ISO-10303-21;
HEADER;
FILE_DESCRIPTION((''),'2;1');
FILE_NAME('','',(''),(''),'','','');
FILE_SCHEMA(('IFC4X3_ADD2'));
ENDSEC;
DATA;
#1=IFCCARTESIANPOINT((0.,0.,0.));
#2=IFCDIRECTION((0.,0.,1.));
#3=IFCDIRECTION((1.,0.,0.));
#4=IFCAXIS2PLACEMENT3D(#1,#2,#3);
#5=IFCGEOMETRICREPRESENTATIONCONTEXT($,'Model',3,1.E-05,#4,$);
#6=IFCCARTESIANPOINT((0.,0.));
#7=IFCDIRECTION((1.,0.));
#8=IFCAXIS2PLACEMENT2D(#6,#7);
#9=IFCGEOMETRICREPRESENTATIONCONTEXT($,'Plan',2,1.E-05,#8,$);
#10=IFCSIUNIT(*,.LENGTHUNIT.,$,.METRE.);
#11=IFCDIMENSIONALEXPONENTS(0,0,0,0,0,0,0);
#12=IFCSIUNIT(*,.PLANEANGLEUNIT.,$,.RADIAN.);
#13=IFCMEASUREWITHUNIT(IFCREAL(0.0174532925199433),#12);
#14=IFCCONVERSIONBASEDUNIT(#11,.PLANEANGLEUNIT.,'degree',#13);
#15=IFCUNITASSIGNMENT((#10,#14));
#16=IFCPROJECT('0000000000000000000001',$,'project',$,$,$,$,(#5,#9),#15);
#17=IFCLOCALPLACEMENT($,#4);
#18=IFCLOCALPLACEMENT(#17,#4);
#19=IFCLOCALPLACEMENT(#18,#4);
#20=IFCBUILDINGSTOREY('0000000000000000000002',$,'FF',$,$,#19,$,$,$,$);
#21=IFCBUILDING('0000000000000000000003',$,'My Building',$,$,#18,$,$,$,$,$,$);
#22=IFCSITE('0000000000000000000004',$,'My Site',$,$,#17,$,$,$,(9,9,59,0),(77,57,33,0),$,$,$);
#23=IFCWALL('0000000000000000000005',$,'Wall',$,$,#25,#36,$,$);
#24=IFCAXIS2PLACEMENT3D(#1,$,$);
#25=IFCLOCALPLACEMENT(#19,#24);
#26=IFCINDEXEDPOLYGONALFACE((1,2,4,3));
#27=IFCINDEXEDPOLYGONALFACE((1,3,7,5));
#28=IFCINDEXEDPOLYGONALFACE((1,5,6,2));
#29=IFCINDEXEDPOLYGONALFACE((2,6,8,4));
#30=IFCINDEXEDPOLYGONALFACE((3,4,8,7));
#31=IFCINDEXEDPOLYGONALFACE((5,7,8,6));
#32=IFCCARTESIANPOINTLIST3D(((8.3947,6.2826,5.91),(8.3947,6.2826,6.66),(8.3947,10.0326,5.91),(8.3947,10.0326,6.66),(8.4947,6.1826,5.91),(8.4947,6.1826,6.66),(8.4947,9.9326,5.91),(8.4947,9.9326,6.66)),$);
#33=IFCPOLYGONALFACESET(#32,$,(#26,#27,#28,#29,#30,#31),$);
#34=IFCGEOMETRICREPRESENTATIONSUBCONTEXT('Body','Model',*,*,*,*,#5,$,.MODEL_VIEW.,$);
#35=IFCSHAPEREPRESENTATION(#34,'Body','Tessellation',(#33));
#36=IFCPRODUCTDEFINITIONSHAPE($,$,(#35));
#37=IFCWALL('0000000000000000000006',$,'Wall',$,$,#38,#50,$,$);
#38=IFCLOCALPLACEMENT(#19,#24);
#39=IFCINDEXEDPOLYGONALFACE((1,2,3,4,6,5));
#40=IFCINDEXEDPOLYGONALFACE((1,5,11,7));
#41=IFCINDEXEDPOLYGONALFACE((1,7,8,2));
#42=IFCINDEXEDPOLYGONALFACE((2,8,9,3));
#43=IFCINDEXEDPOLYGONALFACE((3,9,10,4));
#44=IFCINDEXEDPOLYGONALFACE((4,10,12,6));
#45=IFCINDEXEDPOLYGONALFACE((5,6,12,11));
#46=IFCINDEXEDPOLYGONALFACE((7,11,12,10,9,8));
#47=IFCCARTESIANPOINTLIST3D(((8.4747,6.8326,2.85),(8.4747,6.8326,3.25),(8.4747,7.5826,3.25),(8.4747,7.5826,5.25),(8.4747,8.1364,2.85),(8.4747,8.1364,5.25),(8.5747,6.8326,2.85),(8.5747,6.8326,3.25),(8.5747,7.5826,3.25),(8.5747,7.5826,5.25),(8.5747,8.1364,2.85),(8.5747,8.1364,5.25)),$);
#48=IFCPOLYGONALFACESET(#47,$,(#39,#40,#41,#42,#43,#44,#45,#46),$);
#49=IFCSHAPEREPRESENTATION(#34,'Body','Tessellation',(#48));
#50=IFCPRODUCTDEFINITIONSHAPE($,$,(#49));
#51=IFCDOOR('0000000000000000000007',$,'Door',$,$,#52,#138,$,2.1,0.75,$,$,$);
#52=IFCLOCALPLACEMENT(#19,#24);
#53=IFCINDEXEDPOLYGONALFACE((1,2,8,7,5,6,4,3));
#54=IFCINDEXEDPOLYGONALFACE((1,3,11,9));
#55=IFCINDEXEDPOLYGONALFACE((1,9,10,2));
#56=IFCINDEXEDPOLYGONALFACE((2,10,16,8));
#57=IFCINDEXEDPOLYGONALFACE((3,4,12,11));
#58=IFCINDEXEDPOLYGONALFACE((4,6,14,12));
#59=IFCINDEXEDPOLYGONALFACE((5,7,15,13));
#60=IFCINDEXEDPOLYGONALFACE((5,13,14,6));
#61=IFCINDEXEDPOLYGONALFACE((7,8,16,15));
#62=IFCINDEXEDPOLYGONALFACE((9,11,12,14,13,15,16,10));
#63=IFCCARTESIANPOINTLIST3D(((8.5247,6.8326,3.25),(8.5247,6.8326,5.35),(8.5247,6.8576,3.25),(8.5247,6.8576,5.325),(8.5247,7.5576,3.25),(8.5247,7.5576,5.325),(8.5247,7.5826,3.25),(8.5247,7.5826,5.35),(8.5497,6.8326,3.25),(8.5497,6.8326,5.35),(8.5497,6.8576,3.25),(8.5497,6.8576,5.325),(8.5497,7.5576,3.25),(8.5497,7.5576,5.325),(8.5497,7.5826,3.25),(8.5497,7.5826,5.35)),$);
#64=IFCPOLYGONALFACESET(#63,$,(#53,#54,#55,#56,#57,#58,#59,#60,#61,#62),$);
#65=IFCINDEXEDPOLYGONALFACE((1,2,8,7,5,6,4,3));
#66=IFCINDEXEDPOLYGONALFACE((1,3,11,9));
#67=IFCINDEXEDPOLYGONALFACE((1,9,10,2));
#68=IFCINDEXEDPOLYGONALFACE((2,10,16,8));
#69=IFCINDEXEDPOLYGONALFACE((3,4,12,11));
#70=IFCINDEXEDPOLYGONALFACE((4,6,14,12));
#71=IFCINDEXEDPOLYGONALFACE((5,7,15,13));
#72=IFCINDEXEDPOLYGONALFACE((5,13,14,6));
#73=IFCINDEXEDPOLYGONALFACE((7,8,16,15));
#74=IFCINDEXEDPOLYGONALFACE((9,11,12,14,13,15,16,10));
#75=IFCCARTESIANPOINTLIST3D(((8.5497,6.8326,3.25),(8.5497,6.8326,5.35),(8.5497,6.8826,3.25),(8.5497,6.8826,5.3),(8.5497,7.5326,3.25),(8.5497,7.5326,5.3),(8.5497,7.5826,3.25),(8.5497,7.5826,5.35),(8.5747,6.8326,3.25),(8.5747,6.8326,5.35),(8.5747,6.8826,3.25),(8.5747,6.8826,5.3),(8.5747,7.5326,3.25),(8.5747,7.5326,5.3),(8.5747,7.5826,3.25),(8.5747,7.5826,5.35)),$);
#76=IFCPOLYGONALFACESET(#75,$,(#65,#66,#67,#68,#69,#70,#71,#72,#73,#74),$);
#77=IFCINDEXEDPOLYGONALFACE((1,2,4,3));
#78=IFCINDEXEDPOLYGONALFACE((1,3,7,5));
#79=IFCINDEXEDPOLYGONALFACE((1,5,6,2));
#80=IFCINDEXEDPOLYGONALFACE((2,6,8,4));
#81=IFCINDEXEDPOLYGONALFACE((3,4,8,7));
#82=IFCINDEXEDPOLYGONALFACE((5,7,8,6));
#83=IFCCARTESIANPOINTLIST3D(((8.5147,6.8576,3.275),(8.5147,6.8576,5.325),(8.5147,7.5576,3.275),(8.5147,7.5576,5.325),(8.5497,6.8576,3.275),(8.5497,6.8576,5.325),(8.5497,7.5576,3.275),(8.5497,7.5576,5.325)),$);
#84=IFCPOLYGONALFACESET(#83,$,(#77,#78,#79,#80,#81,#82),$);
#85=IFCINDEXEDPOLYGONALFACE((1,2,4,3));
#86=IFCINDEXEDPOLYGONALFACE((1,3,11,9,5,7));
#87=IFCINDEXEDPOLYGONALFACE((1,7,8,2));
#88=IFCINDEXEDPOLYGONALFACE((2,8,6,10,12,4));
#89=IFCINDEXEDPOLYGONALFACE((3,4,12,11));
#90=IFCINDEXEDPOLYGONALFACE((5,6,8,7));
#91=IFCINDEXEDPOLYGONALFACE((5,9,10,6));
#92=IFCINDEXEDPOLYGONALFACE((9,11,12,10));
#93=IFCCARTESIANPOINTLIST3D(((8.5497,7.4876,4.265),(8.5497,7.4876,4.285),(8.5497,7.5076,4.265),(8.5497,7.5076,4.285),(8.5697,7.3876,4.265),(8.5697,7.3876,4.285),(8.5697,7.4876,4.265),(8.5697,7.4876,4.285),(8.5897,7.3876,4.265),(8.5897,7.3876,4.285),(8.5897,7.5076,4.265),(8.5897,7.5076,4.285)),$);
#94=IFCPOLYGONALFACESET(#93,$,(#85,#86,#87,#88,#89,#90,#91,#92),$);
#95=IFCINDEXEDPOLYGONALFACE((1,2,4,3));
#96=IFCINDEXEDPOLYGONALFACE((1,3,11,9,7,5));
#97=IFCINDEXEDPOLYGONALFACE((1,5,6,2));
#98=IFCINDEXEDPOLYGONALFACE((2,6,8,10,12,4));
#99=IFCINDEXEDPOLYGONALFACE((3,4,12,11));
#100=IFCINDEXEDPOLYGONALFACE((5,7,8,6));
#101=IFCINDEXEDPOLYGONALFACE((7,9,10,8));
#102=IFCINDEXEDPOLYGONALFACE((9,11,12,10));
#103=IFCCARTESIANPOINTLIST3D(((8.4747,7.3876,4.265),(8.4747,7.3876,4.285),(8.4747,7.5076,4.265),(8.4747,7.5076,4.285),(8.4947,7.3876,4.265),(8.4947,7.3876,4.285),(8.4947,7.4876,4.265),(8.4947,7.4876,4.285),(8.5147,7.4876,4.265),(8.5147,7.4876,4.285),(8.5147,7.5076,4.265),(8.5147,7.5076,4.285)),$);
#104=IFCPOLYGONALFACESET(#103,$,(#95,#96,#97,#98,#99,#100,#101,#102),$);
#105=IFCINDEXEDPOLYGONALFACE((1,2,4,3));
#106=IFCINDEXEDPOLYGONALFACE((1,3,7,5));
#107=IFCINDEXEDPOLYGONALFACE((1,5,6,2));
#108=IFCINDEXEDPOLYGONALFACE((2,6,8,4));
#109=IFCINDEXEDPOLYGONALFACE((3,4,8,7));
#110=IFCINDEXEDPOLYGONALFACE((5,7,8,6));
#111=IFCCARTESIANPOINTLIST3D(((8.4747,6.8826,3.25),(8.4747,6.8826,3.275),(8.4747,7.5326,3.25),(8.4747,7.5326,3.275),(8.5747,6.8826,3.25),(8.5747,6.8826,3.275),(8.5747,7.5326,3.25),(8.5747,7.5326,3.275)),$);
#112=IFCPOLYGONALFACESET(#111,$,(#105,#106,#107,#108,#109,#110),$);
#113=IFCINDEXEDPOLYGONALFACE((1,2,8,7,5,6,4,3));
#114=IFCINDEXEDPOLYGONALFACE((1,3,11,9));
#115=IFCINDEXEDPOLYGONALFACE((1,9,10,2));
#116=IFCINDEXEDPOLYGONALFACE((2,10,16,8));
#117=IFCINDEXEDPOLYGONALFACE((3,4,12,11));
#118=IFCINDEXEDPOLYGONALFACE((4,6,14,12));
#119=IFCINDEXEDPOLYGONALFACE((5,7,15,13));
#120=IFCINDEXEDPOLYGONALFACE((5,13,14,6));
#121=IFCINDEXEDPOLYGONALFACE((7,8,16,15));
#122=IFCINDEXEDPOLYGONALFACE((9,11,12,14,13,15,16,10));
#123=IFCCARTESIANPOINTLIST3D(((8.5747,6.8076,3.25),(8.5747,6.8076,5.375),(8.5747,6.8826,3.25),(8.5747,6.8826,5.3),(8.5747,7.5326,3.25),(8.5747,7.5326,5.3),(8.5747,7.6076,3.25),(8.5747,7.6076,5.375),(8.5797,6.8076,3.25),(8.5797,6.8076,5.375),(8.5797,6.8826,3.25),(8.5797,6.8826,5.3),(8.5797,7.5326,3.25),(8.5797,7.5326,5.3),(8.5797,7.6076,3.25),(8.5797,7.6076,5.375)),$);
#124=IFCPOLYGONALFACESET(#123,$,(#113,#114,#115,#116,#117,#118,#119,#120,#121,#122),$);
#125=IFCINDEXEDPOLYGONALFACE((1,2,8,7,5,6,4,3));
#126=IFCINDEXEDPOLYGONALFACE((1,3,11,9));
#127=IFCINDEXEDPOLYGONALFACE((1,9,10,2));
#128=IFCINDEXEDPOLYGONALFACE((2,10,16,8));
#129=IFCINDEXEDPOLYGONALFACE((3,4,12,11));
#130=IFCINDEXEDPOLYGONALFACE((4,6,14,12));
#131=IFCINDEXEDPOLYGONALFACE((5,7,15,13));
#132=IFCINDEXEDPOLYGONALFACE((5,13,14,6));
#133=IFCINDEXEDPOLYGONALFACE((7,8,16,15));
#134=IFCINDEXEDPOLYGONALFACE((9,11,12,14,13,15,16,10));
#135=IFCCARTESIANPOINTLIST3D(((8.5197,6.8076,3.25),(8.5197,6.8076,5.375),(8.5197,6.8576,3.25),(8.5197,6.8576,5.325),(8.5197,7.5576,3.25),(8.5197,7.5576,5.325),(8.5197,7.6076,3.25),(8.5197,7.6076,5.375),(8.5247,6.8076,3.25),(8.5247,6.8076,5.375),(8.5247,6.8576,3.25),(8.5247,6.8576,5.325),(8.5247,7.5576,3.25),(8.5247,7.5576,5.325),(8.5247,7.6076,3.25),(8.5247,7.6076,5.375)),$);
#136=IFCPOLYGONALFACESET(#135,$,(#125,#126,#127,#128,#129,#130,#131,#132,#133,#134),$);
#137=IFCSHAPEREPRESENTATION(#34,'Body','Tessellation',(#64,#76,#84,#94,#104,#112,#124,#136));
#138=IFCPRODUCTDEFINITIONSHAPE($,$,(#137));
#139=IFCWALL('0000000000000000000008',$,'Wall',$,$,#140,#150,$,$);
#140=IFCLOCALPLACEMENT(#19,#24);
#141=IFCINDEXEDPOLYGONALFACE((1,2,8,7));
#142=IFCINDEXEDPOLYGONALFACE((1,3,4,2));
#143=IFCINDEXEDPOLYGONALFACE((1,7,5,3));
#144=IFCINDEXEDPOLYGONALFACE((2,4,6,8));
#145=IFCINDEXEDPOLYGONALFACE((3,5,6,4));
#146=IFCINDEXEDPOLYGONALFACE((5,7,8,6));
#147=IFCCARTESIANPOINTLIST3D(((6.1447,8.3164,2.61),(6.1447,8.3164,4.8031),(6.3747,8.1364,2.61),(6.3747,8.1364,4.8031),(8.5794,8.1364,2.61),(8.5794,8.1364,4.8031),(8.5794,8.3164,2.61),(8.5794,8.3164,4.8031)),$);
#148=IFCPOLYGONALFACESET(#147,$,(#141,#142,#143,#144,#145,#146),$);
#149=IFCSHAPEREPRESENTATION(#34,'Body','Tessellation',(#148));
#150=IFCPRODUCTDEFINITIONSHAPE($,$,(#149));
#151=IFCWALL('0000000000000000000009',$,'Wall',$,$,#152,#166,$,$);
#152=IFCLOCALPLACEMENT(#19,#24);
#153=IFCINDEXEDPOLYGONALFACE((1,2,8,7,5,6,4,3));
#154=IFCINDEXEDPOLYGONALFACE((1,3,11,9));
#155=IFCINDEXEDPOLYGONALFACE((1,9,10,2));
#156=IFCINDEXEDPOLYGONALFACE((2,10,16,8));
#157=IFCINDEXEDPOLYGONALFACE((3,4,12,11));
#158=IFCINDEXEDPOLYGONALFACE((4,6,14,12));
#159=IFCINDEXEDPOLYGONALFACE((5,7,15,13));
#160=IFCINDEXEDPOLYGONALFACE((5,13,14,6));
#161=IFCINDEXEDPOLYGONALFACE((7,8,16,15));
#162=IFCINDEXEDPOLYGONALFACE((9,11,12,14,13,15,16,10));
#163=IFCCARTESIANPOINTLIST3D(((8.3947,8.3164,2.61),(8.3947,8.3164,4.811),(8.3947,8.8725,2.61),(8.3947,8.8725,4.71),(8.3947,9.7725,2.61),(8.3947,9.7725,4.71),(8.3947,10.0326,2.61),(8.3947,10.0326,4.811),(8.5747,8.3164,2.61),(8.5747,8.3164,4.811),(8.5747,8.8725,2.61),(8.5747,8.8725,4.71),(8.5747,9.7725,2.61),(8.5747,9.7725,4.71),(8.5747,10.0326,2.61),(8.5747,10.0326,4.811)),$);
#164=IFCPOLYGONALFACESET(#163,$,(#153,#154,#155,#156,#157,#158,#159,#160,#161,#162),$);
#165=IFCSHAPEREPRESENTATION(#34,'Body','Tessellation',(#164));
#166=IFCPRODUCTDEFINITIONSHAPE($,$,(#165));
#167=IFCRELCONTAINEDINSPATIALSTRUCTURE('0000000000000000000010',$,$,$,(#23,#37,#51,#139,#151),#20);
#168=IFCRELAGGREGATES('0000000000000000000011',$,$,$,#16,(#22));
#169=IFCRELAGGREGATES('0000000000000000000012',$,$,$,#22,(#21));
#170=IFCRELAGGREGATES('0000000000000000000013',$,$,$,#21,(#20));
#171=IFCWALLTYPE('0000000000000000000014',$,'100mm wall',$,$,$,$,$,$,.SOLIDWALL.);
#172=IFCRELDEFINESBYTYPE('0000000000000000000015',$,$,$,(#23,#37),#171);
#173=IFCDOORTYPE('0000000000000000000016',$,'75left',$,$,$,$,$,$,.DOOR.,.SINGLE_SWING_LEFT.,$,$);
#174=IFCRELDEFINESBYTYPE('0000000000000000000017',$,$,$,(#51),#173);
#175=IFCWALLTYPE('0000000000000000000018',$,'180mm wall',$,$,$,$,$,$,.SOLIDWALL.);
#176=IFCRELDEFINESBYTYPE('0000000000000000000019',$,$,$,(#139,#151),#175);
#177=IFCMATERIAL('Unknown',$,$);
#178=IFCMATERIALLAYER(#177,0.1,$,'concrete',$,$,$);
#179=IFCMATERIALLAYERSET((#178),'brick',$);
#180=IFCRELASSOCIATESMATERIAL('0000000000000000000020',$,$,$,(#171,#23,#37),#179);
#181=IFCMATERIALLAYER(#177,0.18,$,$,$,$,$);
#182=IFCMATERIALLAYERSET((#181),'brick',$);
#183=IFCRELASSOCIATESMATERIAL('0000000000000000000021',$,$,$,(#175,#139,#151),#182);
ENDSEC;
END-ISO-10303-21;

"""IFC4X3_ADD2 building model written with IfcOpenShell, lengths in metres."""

from ifc_helpers import new_model, entity, si_unit, converted_unit, frame, origin_with_axes, origin_2d_with_axis, place, context, subcontext, project, spatial, line, indexed_curve, outline, extrude, shape, source, transform, mapped, material, layer, layer_set, layer_usage, type_object, type_shapes, element, fill, save


model = new_model("IFC4X3_ADD2")

# Units and contexts
model_context = context("Model", 3, precision=1e-05, world=origin_with_axes())
plan_context = context("Plan", 2, precision=1e-05, world=origin_2d_with_axis())
body_context_1 = subcontext(model_context, "Body", "Model", "MODEL_VIEW")
body_context_2 = subcontext(plan_context, "Body", "Plan", "PLAN_VIEW")
ifc_project = project(units=[si_unit("LENGTHUNIT", "METRE"), converted_unit("PLANEANGLEUNIT", "degree", entity("IfcReal", 0.0174532925199433), si_unit("PLANEANGLEUNIT", "RADIAN"), dimensions=[0, 0, 0, 0, 0, 0, 0])], contexts=[model_context, plan_context])

# Site, building, storey
site_placement = place(None, origin_with_axes())
site = spatial("IfcSite", under=ifc_project, at=site_placement, Name="My Site", RefLatitude=(9, 9, 59, 0), RefLongitude=(77, 57, 33, 0))
building_placement = place(site_placement, origin_with_axes())
building = spatial("IfcBuilding", under=site, at=building_placement, Name="My Building")
storey_placement = place(building_placement, origin_with_axes())
storey = spatial("IfcBuildingStorey", under=building, at=storey_placement, Name="FF")

# Shared definitions
ifc_material = material(Name="Unknown")

# Wall
ifc_layer_1 = layer(ifc_material, 0.1, Name="concrete")
ifc_layer_set_1 = layer_set([ifc_layer_1], Name="brick")
wall_type_1 = type_object("IfcWallType", Name="100mm wall", PredefinedType="SOLIDWALL", material=ifc_layer_set_1)
ifc_layer_usage_1 = layer_usage(ifc_layer_set_1, "AXIS2", "POSITIVE", 0.0)
wall_1_placement = place(storey_placement, frame((8.3947, 10.0326, 5.91), z_axis=(0.0, 0.0, 1.0), x_axis=(-0.000001, -1.0, 0.0)))
element("IfcWall", 1, at=wall_1_placement, inside=storey, type_object=wall_type_1, material=ifc_layer_usage_1, Name="Wall", context=body_context_1, shape_type="SweptSolid", body=[
    extrude(outline(indexed_curve([(0.0, 0.0), (0.1, 0.1), (3.85, 0.1), (3.75, 0.0)], segments=[line(1, 2, 3, 4, 1)])), origin_with_axes(), (0.0, 0.0, 1.0), 0.75),
])

# Wall, opening, door
ifc_layer_usage_2 = layer_usage(ifc_layer_set_1, "AXIS2", "POSITIVE", 0.0)
wall_2_placement = place(storey_placement, frame((8.5747, 6.8326, 2.85), z_axis=(0.0, 0.0, 1.0), x_axis=(0.0, 1.0, 0.0)))
wall_2 = element("IfcWall", 2, at=wall_2_placement, inside=storey, type_object=wall_type_1, material=ifc_layer_usage_2, Name="Wall", context=body_context_1, shape_type="SweptSolid", body=[
    extrude(outline(indexed_curve([(0.0, 0.0), (0.0, 0.1), (1.3039, 0.1), (1.3039, 0.0)], segments=[line(1, 2, 3, 4, 1)])), origin_with_axes(), (0.0, 0.0, 1.0), 2.4),
])
shared_shape_1 = source(origin_with_axes(), body_context_1, "Body", "SweptSolid", [
    extrude(outline(indexed_curve([(0.0, 0.0), (0.75, 0.0), (0.75, 2.1), (0.0, 2.1)], segments=[line(1, 2, 3, 4, 1)])), frame((0.0, -0.6, 0.0), z_axis=(0.0, -1.0, 0.0), x_axis=(1.0, 0.0, 0.0)), (0.0, 0.0, -1.0), 1.2),
])
opening_1_placement = place(wall_2_placement, frame((0.0, 0.0, 0.4), z_axis=(0.0, 0.0, 1.0), x_axis=(1.0, 0.0, 0.0)))
opening_1 = element("IfcOpeningElement", 3, at=opening_1_placement, cuts=wall_2, PredefinedType="OPENING", context=body_context_1, shape_type="MappedRepresentation", body=[
    mapped(shared_shape_1, transform((0.0, 0.0, 0.0), x_axis=(1.0, 0.0, 0.0), y_axis=(0.0, 1.0, 0.0), z_axis=(0.0, 0.0, 1.0), scale=1.0)),
])
door_type_1 = type_object("IfcDoorType", Name="75left", OperationType="SINGLE_SWING_LEFT", PredefinedType="DOOR")
shared_shape_2 = source(origin_with_axes(), body_context_1, "Body", "SweptSolid", [
    extrude(outline(indexed_curve([(0.0, 0.0), (0.0, 2.1), (0.75, 2.1), (0.75, 0.0), (0.725, 0.0), (0.725, 2.075), (0.025, 2.075), (0.025, 0.0)], segments=[line(1, 2, 3, 4, 5, 6, 7, 8, 1)])), frame((0.0, 0.025, 0.0), z_axis=(0.0, -1.0, 0.0), x_axis=(1.0, 0.0, 0.0)), (0.0, 0.0, -1.0), 0.025),
    extrude(outline(indexed_curve([(0.0, 0.0), (0.0, 2.1), (0.75, 2.1), (0.75, 0.0), (0.7, 0.0), (0.7, 2.05), (0.05, 2.05), (0.05, 0.0)], segments=[line(1, 2, 3, 4, 5, 6, 7, 8, 1)])), frame((0.0, 0.0, 0.0), z_axis=(0.0, -1.0, 0.0), x_axis=(1.0, 0.0, 0.0)), (0.0, 0.0, -1.0), 0.025),
    extrude(outline(indexed_curve([(0.0, 0.0), (0.7, 0.0), (0.7, 0.035), (0.0, 0.035)], segments=[line(1, 2, 3, 4, 1)])), frame((0.025, 0.025, 0.025), z_axis=(0.0, 0.0, 1.0), x_axis=(1.0, 0.0, 0.0)), (0.0, 0.0, 1.0), 2.05),
    extrude(outline(indexed_curve([(0.0, 0.0), (0.0, -0.04), (-0.12, -0.04), (-0.12, -0.02), (-0.02, -0.02), (-0.02, 0.0)], segments=[line(1, 2, 3, 4, 5, 6, 1)])), frame((0.675, 0.025, 1.015), z_axis=(0.0, 0.0, 1.0), x_axis=(1.0, 0.0, 0.0)), (0.0, 0.0, 1.0), 0.02),
    extrude(outline(indexed_curve([(0.0, 0.0), (0.0, 0.04), (-0.12, 0.04), (-0.12, 0.02), (-0.02, 0.02), (-0.02, 0.0)], segments=[line(1, 2, 3, 4, 5, 6, 1)])), frame((0.675, 0.06, 1.015), z_axis=(0.0, 0.0, 1.0), x_axis=(1.0, 0.0, 0.0)), (0.0, 0.0, 1.0), 0.02),
    extrude(outline(indexed_curve([(0.0, 0.0), (0.65, 0.0), (0.65, 0.1), (0.0, 0.1)], segments=[line(1, 2, 3, 4, 1)])), frame((0.05, 0.0, 0.0), z_axis=(0.0, 0.0, 1.0), x_axis=(1.0, 0.0, 0.0)), (0.0, 0.0, 1.0), 0.025),
    extrude(outline(indexed_curve([(0.0, 0.0), (0.0, 2.125), (0.8, 2.125), (0.8, 0.0), (0.725, 0.0), (0.725, 2.05), (0.075, 2.05), (0.075, 0.0)], segments=[line(1, 2, 3, 4, 5, 6, 7, 8, 1)])), frame((-0.025, -0.005, 0.0), z_axis=(0.0, -1.0, 0.0), x_axis=(1.0, 0.0, 0.0)), (0.0, 0.0, -1.0), 0.005),
    extrude(outline(indexed_curve([(0.0, 0.0), (0.0, 2.125), (0.8, 2.125), (0.8, 0.0), (0.75, 0.0), (0.75, 2.075), (0.05, 2.075), (0.05, 0.0)], segments=[line(1, 2, 3, 4, 5, 6, 7, 8, 1)])), frame((-0.025, 0.05, 0.0), z_axis=(0.0, -1.0, 0.0), x_axis=(1.0, 0.0, 0.0)), (0.0, 0.0, -1.0), 0.005),
])
shared_shape_3 = source(origin_with_axes(), body_context_2, "Body", "Curve2D", [
    entity("IfcIndexedPolyCurve", entity("IfcCartesianPointList2D", [[0.0, 0.0], [0.0, 0.05], [0.025, 0.05], [0.025, 0.025], [0.05, 0.025], [0.05, 0.0]]), [entity("IfcLineIndex", [1, 2, 3, 4, 5, 6, 1])]),
    entity("IfcIndexedPolyCurve", entity("IfcCartesianPointList2D", [[0.75, 0.0], [0.75, 0.05], [0.725, 0.05], [0.725, 0.025], [0.7, 0.025], [0.7, 0.0]]), [entity("IfcLineIndex", [1, 2, 3, 4, 5, 6, 1])]),
    entity("IfcTrimmedCurve", entity("IfcEllipse", entity("IfcAxis2Placement2D", entity("IfcCartesianPoint", [0.06, 0.05]), entity("IfcDirection", [1.0, 0.0])), 0.665, 0.7), [entity("IfcCartesianPoint", [0.725, 0.05])], [entity("IfcCartesianPoint", [0.06, 0.75])], True, "CARTESIAN"),
    entity("IfcIndexedPolyCurve", entity("IfcCartesianPointList2D", [[0.025, 0.05], [0.06, 0.05], [0.06, 0.75], [0.025, 0.75]]), [entity("IfcLineIndex", [1, 2, 3, 4, 1])]),
])
type_shapes(door_type_1, [shared_shape_2, shared_shape_3])
door_1_placement = place(opening_1_placement, frame((0.0, 0.0, 0.0), z_axis=(0.0, 0.0, 1.0), x_axis=(1.0, 0.0, 0.0)))
door_1 = element("IfcDoor", 4, at=door_1_placement, inside=storey, type_object=door_type_1, Name="Door", OverallHeight=2.1, OverallWidth=0.75, shapes=[
    shape(body_context_1, "Body", "MappedRepresentation", [mapped(shared_shape_2, transform((0.0, 0.0, 0.0), x_axis=(1.0, 0.0, 0.0), y_axis=(0.0, 1.0, 0.0), z_axis=(0.0, 0.0, 1.0), scale=1.0))]),
    shape(body_context_2, "Body", "MappedRepresentation", [mapped(shared_shape_3, transform((0.0, 0.0, 0.0), x_axis=(1.0, 0.0, 0.0), y_axis=(0.0, 1.0, 0.0), z_axis=(0.0, 0.0, 1.0), scale=1.0))]),
])
fill(opening_1, door_1)

# Wall
ifc_layer_2 = layer(ifc_material, 0.18)
ifc_layer_set_2 = layer_set([ifc_layer_2], Name="brick")
ifc_layer_usage_3 = layer_usage(ifc_layer_set_2, "AXIS2", "POSITIVE", 0.0)
wall_type_2 = type_object("IfcWallType", Name="180mm wall", PredefinedType="SOLIDWALL", material=ifc_layer_set_2)
wall_3_placement = place(storey_placement, frame((8.5794, 8.3164, 2.61), z_axis=(0.0, 0.0, 1.0), x_axis=(-1.0, 0.0, 0.0)))
element("IfcWall", 5, at=wall_3_placement, inside=storey, type_object=wall_type_2, material=ifc_layer_usage_3, Name="Wall", context=body_context_1, shape_type="SweptSolid", body=[
    extrude(outline(indexed_curve([(0.0, 0.0), (0.0, 0.18), (2.2047, 0.18), (2.4347, 0.0)], segments=[line(1, 2, 3, 4, 1)])), origin_with_axes(), (0.0, 0.0, 1.0), 2.1931),
])

# Wall, opening
ifc_layer_usage_4 = layer_usage(ifc_layer_set_2, "AXIS2", "POSITIVE", 0.0)
wall_4_placement = place(storey_placement, frame((8.5747, 8.3164, 2.61), z_axis=(0.0, 0.0, 1.0), x_axis=(0.0, 1.0, 0.0)))
wall_4 = element("IfcWall", 6, at=wall_4_placement, inside=storey, type_object=wall_type_2, material=ifc_layer_usage_4, Name="Wall", context=body_context_1, shape_type="SweptSolid", body=[
    extrude(outline(indexed_curve([(0.0, 0.0), (0.0, 0.18), (1.7161, 0.18), (1.7161, 0.0)], segments=[line(1, 2, 3, 4, 1)])), origin_with_axes(), (0.0, 0.0, 1.0), 2.201),
])
shared_shape_4 = source(origin_with_axes(), body_context_1, "Body", "SweptSolid", [
    extrude(outline(indexed_curve([(0.0, 0.0), (0.9, 0.0), (0.9, 2.1), (0.0, 2.1)], segments=[line(1, 2, 3, 4, 1)])), frame((0.0, -0.6, 0.0), z_axis=(0.0, -1.0, 0.0), x_axis=(1.0, 0.0, 0.0)), (0.0, 0.0, -1.0), 1.2),
])
opening_2_placement = place(wall_4_placement, frame((1.456, 0.0928, 0.0), z_axis=(0.0, 0.0, 1.0), x_axis=(-1.0, 0.0, 0.0)))
element("IfcOpeningElement", 7, at=opening_2_placement, cuts=wall_4, PredefinedType="OPENING", context=body_context_1, shape_type="MappedRepresentation", body=[
    mapped(shared_shape_4, transform((0.0, 0.0, 0.0), x_axis=(1.0, 0.0, 0.0), y_axis=(0.0, 1.0, 0.0), z_axis=(0.0, 0.0, 1.0), scale=1.0)),
])

save(model, "model.ifc")
